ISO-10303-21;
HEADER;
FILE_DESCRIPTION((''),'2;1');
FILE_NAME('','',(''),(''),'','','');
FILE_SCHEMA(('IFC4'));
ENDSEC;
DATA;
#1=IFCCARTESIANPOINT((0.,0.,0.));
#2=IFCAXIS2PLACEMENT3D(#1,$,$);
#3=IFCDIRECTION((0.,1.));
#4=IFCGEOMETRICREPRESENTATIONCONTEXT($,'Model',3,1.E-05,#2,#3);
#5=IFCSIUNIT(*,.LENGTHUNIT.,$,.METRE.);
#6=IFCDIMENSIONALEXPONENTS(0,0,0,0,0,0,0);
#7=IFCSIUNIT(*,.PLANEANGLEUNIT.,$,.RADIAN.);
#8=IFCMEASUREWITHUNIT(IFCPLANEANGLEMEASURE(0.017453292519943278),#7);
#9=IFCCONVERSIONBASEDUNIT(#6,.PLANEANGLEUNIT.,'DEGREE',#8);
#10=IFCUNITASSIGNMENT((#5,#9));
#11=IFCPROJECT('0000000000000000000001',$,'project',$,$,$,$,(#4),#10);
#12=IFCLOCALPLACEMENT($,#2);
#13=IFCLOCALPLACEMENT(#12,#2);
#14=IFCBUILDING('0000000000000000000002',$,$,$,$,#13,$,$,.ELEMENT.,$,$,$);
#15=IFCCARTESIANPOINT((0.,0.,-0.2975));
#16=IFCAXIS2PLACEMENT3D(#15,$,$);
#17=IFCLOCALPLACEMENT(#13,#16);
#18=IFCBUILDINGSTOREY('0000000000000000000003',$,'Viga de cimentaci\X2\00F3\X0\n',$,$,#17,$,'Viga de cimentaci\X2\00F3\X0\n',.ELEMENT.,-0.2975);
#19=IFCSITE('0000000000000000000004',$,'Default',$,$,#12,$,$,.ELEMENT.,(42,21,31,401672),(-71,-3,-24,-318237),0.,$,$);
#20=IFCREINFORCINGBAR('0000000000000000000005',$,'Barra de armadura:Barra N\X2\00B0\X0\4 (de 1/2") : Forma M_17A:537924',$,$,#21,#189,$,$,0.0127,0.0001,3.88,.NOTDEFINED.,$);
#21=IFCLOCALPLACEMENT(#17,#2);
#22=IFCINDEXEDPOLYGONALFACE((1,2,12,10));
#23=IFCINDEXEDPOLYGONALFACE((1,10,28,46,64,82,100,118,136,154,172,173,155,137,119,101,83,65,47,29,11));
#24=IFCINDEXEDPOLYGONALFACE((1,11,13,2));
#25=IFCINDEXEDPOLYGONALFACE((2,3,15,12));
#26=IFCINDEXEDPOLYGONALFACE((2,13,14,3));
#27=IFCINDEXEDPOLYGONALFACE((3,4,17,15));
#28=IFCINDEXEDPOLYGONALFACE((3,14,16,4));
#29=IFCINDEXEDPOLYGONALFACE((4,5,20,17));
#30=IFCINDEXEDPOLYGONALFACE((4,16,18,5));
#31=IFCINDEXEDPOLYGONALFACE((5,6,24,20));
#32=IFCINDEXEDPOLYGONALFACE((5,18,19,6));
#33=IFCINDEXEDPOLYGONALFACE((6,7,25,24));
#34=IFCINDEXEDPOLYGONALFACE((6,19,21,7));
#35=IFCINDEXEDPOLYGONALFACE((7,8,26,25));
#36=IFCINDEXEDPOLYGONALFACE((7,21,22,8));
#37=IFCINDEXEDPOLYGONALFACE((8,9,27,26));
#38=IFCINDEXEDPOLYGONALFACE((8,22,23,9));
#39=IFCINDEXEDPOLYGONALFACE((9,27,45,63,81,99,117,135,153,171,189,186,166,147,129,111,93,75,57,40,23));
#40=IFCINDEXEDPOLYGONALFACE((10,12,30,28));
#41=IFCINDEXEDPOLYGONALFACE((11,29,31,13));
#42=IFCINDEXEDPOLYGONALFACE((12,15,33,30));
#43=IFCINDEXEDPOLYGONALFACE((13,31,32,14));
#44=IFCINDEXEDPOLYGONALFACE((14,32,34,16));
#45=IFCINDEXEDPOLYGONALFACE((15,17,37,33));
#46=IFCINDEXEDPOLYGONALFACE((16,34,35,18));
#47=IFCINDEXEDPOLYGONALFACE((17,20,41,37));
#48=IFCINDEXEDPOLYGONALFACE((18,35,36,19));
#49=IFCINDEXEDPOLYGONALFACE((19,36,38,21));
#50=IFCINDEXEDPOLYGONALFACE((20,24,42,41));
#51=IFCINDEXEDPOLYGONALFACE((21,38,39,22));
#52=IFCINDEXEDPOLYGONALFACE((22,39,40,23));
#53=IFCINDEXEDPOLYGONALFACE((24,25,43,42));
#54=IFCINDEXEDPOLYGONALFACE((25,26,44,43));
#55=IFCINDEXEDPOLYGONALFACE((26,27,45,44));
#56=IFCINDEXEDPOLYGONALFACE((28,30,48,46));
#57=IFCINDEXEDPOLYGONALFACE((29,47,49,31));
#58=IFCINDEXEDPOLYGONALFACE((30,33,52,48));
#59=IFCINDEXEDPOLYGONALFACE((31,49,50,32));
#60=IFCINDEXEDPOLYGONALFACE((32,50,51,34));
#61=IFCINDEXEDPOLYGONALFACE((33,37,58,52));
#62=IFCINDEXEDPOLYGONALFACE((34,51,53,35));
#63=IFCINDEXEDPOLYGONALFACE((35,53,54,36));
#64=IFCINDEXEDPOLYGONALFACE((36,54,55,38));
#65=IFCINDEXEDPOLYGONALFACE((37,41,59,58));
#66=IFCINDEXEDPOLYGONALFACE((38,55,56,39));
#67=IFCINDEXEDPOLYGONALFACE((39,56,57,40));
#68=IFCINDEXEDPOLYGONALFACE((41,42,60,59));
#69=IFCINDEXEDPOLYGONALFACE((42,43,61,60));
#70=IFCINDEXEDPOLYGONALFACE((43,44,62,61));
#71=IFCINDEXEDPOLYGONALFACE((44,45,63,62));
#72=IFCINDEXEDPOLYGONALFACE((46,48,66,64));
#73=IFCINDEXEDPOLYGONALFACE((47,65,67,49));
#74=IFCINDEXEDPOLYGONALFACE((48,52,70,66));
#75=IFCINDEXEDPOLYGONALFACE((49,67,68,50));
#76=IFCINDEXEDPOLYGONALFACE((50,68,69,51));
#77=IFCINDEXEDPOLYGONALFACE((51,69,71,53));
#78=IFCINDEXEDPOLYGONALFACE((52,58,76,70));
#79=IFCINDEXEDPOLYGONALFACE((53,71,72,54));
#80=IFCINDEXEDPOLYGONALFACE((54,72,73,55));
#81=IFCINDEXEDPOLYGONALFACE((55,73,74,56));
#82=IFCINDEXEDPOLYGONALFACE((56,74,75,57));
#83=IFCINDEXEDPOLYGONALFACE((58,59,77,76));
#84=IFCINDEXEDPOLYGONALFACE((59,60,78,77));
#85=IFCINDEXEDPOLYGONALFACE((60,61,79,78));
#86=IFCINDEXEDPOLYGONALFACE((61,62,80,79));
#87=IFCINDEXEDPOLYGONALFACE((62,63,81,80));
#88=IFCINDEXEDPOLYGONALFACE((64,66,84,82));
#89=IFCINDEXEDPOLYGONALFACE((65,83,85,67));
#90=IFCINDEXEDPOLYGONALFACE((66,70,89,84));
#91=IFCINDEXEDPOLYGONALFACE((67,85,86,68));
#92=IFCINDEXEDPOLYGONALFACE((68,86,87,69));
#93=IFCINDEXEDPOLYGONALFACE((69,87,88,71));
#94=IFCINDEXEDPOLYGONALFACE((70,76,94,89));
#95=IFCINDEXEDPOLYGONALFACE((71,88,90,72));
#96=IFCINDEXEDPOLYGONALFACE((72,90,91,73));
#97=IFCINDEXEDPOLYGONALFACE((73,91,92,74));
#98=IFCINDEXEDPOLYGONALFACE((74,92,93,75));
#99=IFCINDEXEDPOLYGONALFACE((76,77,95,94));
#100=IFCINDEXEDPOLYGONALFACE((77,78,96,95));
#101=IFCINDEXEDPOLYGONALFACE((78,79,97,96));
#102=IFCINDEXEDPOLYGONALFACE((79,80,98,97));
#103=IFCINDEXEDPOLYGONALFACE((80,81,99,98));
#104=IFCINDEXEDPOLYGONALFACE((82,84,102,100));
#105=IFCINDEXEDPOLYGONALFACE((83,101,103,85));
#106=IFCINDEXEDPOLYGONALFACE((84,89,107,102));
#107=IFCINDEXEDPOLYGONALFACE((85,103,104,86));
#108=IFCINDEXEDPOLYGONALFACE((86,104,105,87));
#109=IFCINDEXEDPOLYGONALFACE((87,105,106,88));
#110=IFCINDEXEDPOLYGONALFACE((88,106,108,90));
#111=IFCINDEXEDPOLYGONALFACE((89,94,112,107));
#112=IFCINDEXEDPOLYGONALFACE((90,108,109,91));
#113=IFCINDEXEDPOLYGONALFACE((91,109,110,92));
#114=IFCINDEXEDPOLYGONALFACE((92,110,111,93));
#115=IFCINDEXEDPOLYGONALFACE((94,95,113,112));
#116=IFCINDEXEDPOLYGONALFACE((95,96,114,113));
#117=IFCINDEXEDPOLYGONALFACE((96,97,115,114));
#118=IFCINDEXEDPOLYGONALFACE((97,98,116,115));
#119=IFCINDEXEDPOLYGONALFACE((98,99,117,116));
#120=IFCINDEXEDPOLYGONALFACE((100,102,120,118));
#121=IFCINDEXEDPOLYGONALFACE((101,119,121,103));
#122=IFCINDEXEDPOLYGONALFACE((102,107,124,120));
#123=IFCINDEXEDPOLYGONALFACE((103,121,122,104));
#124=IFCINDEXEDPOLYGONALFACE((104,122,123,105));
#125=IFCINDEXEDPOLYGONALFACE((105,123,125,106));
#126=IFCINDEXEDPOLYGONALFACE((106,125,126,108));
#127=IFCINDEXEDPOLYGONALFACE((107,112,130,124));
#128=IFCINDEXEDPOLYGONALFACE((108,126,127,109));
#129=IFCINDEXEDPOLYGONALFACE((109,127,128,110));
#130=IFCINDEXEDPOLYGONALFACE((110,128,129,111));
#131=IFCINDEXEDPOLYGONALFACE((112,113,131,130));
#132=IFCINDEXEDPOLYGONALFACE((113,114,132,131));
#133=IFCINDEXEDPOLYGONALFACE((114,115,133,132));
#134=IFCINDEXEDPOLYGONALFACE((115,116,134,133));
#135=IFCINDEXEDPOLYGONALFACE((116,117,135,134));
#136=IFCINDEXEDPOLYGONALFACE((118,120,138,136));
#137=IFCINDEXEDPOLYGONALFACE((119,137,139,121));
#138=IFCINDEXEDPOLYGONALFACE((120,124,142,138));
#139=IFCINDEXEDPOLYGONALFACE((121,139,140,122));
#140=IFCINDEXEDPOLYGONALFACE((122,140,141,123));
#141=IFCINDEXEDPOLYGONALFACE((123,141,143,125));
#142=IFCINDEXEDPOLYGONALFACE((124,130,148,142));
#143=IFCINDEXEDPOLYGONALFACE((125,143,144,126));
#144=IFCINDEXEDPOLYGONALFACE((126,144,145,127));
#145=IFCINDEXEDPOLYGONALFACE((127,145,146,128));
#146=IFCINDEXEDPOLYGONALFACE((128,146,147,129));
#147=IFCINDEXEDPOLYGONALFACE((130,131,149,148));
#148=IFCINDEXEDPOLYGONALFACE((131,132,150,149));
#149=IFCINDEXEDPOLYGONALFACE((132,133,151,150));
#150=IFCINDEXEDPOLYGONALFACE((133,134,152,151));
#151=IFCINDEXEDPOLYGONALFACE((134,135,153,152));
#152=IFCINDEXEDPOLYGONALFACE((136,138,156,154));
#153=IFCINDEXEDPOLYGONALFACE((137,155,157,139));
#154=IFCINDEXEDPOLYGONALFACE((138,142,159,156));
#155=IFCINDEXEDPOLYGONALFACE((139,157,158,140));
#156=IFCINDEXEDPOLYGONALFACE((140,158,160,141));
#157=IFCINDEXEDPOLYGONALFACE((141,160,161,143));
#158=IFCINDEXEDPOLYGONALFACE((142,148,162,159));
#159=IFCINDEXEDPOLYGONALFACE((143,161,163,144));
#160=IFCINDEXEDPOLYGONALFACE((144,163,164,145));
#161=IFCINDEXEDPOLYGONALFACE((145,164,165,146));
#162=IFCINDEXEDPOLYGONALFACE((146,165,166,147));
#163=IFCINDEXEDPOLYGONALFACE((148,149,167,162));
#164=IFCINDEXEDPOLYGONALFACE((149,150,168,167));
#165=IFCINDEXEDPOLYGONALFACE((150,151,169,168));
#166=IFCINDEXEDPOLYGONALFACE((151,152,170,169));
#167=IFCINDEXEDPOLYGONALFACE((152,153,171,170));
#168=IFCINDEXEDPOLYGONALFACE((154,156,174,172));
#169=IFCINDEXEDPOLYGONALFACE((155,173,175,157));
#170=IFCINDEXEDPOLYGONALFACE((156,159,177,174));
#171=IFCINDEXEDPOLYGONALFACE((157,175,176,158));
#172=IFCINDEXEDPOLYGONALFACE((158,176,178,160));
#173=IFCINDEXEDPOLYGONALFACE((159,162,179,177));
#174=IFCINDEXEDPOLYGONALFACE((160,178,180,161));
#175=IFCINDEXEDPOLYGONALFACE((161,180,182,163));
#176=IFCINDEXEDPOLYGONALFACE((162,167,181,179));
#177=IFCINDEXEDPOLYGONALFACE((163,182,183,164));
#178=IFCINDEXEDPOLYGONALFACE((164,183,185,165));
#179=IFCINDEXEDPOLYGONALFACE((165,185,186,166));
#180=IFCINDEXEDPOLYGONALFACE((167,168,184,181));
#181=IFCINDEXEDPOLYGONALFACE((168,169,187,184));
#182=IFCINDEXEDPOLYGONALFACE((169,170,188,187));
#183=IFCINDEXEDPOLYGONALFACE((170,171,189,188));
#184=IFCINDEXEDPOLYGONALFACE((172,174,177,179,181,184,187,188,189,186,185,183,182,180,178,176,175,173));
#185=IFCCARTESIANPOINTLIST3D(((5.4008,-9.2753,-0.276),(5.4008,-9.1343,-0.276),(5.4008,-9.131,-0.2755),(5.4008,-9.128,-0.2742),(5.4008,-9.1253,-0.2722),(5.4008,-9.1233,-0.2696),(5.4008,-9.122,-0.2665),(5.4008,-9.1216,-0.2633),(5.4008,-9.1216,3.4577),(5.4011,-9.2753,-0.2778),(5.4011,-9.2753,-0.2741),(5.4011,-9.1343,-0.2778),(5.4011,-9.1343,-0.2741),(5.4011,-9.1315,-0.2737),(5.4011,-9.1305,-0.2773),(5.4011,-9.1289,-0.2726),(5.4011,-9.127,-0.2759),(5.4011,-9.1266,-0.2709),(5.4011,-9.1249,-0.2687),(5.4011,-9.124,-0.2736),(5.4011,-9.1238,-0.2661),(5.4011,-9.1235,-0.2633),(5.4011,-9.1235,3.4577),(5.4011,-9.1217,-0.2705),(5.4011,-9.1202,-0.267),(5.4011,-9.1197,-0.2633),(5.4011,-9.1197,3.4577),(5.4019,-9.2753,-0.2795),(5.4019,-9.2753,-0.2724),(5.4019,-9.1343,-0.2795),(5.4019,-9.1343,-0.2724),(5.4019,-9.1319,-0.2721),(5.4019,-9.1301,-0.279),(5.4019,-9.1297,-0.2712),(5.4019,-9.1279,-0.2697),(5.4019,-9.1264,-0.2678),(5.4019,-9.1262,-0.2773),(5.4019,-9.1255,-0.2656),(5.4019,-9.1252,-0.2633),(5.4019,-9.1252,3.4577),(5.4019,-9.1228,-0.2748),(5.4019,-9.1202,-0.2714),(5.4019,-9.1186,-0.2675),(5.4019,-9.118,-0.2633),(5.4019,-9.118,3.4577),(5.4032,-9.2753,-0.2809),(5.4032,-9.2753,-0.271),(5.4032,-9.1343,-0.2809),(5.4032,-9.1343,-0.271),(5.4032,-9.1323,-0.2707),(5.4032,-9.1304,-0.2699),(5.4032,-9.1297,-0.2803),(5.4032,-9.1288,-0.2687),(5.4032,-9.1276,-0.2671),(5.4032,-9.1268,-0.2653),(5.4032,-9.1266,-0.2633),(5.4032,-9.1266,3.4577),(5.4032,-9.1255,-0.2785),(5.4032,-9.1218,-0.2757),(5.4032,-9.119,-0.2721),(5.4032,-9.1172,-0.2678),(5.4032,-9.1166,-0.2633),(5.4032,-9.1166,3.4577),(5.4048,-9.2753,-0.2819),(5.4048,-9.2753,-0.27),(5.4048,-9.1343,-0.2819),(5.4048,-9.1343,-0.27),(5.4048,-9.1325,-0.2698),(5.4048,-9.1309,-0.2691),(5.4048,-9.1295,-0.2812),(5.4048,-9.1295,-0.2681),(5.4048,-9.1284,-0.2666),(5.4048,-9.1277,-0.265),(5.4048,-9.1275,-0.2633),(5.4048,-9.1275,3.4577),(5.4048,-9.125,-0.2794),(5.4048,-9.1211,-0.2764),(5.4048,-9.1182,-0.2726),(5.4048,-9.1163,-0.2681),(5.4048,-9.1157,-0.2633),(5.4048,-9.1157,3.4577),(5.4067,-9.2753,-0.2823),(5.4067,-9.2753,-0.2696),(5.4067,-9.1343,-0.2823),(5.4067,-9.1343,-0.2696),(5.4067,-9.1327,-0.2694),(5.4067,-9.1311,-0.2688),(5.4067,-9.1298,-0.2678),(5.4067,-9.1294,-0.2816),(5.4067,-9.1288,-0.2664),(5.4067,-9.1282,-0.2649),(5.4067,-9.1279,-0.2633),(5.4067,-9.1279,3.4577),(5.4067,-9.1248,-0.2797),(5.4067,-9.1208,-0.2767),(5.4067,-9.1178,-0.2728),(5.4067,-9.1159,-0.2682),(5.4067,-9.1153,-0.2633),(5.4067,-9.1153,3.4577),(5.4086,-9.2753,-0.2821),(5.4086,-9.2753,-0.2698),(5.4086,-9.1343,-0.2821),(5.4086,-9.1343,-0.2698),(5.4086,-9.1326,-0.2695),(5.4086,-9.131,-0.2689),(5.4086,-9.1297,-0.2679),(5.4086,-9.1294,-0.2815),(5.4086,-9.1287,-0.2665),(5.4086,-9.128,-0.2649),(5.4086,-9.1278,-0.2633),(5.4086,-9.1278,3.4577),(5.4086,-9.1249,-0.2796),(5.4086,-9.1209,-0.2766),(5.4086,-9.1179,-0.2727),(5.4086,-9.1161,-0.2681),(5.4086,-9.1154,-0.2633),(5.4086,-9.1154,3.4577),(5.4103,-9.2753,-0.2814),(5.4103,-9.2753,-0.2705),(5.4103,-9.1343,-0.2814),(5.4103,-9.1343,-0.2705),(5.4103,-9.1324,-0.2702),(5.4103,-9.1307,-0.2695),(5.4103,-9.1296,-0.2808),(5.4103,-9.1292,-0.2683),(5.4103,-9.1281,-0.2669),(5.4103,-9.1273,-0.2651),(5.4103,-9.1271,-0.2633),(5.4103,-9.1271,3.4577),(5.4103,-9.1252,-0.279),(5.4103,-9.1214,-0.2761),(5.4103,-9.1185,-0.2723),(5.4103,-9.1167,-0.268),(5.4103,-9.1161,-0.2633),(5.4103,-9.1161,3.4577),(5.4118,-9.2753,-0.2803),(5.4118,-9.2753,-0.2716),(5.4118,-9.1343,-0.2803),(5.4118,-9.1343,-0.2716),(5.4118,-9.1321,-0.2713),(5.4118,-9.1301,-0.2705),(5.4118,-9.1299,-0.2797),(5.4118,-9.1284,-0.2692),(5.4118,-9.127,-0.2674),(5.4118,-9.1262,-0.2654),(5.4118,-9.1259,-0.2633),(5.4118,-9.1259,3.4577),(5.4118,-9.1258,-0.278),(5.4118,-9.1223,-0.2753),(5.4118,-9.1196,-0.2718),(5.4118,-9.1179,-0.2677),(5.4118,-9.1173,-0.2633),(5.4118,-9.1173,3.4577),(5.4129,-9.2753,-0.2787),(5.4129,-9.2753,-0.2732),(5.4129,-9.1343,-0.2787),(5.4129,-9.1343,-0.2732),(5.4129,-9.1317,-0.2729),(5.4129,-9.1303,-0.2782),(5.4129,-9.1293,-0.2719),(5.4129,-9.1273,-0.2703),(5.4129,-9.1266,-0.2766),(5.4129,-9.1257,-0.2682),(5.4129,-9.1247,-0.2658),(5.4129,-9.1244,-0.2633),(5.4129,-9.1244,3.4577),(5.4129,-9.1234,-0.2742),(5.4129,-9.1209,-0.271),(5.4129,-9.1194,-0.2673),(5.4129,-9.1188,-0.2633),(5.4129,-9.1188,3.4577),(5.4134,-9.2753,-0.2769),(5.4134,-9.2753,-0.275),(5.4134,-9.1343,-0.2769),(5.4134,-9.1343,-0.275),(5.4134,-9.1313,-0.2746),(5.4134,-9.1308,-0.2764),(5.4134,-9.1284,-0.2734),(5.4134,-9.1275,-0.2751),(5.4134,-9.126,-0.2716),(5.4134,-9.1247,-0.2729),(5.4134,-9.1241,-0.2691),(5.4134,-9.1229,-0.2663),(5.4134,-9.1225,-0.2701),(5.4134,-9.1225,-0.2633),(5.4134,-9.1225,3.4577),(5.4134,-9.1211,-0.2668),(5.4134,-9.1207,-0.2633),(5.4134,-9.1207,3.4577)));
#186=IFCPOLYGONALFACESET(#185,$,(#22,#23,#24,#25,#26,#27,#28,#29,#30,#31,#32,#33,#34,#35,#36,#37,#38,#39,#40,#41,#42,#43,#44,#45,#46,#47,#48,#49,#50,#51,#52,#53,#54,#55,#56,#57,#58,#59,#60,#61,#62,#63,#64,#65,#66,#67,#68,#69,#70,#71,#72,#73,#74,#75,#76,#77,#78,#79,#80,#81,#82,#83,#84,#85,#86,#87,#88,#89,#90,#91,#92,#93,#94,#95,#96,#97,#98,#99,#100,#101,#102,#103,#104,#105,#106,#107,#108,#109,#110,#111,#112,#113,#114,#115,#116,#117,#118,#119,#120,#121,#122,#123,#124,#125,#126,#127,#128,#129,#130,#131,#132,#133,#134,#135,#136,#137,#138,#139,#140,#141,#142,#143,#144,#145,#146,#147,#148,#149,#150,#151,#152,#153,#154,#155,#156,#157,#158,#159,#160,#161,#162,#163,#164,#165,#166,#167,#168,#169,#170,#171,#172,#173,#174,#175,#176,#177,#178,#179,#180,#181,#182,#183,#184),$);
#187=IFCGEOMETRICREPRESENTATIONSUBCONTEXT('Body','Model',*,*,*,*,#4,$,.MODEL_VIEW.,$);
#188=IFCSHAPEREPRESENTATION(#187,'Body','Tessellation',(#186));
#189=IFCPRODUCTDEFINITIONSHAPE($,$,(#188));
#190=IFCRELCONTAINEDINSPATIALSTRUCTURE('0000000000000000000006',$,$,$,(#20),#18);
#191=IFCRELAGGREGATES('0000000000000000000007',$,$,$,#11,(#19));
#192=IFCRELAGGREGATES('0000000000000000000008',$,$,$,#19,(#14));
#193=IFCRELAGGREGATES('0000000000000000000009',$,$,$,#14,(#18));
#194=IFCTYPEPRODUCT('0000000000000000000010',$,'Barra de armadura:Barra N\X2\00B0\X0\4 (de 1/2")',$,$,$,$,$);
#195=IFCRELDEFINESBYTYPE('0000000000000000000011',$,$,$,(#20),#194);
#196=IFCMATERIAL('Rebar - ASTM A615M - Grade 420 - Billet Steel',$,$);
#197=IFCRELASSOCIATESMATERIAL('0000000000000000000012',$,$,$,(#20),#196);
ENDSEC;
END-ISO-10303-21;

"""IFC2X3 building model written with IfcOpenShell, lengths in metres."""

from ifc_helpers import new_model, entity, si_unit, converted_unit, direction, frame, origin, place, context, subcontext, project, spatial, material, type_object, element, save


model = new_model("IFC2X3")

# Units and contexts
model_context = context("Model", 3, precision=1e-05, world=origin(), true_north=direction((0.0, 1.0)))
body_context = subcontext(model_context, "Body", "Model", "MODEL_VIEW")
ifc_project = project(units=[si_unit("LENGTHUNIT", "METRE"), converted_unit("PLANEANGLEUNIT", "DEGREE", entity("IfcPlaneAngleMeasure", 0.017453292519943278), si_unit("PLANEANGLEUNIT", "RADIAN"), dimensions=[0, 0, 0, 0, 0, 0, 0])], contexts=[model_context])

# Site, building, storey
site_placement = place(None, origin())
site = spatial("IfcSite", under=ifc_project, at=site_placement, Name="Default", CompositionType="ELEMENT", RefLatitude=(42, 21, 31, 401672), RefLongitude=(-71, -3, -24, -318237), RefElevation=0.0)
building_placement = place(site_placement, origin())
building = spatial("IfcBuilding", under=site, at=building_placement, CompositionType="ELEMENT")
storey_placement = place(building_placement, frame((0.0, 0.0, -0.2975)))
storey = spatial("IfcBuildingStorey", under=building, at=storey_placement, Name="Viga de cimentación", LongName="Viga de cimentación", CompositionType="ELEMENT", Elevation=-0.2975)

# Reinforcing bar
ifc_material_1 = material(Name="Rebar - ASTM A615M - Grade 420 - Billet Steel")
type_product_1 = type_object("IfcTypeProduct", Name="Barra de armadura:Barra N°4 (de 1/2\")")
reinforcing_bar_1_placement = place(storey_placement, origin())
element("IfcReinforcingBar", 1, at=reinforcing_bar_1_placement, inside=storey, type_object=type_product_1, material=ifc_material_1, Name="Barra de armadura:Barra N°4 (de 1/2\") : Forma M_17A:537924", BarLength=3.88, BarRole="NOTDEFINED", CrossSectionArea=0.0001, NominalDiameter=0.0127, context=body_context, shape_type="AdvancedSweptSolid", body=[
    entity("IfcSweptDiskSolid", entity("IfcCompositeCurve", [entity("IfcCompositeCurveSegment", "CONTINUOUS", True, entity("IfcPolyline", [entity("IfcCartesianPoint", [5.4071, -9.1216, 3.4577]), entity("IfcCartesianPoint", [5.4071, -9.1216, -0.2633])])), entity("IfcCompositeCurveSegment", "CONTINUOUS", True, entity("IfcTrimmedCurve", entity("IfcCircle", entity("IfcAxis2Placement3D", entity("IfcCartesianPoint", [5.4071, -9.1343, -0.2633]), entity("IfcDirection", [-1.0, 0.0, 0.0]), entity("IfcDirection", [0.0, 0.0, -1.0])), 0.0127), [entity("IfcParameterValue", 270.0)], [entity("IfcParameterValue", 360.0)], True, "PARAMETER")), entity("IfcCompositeCurveSegment", "CONTINUOUS", True, entity("IfcPolyline", [entity("IfcCartesianPoint", [5.4071, -9.1343, -0.276]), entity("IfcCartesianPoint", [5.4071, -9.2753, -0.276])]))], False), 0.0063, None, 0.0, 92.0),
])

save(model, "model.ifc")
